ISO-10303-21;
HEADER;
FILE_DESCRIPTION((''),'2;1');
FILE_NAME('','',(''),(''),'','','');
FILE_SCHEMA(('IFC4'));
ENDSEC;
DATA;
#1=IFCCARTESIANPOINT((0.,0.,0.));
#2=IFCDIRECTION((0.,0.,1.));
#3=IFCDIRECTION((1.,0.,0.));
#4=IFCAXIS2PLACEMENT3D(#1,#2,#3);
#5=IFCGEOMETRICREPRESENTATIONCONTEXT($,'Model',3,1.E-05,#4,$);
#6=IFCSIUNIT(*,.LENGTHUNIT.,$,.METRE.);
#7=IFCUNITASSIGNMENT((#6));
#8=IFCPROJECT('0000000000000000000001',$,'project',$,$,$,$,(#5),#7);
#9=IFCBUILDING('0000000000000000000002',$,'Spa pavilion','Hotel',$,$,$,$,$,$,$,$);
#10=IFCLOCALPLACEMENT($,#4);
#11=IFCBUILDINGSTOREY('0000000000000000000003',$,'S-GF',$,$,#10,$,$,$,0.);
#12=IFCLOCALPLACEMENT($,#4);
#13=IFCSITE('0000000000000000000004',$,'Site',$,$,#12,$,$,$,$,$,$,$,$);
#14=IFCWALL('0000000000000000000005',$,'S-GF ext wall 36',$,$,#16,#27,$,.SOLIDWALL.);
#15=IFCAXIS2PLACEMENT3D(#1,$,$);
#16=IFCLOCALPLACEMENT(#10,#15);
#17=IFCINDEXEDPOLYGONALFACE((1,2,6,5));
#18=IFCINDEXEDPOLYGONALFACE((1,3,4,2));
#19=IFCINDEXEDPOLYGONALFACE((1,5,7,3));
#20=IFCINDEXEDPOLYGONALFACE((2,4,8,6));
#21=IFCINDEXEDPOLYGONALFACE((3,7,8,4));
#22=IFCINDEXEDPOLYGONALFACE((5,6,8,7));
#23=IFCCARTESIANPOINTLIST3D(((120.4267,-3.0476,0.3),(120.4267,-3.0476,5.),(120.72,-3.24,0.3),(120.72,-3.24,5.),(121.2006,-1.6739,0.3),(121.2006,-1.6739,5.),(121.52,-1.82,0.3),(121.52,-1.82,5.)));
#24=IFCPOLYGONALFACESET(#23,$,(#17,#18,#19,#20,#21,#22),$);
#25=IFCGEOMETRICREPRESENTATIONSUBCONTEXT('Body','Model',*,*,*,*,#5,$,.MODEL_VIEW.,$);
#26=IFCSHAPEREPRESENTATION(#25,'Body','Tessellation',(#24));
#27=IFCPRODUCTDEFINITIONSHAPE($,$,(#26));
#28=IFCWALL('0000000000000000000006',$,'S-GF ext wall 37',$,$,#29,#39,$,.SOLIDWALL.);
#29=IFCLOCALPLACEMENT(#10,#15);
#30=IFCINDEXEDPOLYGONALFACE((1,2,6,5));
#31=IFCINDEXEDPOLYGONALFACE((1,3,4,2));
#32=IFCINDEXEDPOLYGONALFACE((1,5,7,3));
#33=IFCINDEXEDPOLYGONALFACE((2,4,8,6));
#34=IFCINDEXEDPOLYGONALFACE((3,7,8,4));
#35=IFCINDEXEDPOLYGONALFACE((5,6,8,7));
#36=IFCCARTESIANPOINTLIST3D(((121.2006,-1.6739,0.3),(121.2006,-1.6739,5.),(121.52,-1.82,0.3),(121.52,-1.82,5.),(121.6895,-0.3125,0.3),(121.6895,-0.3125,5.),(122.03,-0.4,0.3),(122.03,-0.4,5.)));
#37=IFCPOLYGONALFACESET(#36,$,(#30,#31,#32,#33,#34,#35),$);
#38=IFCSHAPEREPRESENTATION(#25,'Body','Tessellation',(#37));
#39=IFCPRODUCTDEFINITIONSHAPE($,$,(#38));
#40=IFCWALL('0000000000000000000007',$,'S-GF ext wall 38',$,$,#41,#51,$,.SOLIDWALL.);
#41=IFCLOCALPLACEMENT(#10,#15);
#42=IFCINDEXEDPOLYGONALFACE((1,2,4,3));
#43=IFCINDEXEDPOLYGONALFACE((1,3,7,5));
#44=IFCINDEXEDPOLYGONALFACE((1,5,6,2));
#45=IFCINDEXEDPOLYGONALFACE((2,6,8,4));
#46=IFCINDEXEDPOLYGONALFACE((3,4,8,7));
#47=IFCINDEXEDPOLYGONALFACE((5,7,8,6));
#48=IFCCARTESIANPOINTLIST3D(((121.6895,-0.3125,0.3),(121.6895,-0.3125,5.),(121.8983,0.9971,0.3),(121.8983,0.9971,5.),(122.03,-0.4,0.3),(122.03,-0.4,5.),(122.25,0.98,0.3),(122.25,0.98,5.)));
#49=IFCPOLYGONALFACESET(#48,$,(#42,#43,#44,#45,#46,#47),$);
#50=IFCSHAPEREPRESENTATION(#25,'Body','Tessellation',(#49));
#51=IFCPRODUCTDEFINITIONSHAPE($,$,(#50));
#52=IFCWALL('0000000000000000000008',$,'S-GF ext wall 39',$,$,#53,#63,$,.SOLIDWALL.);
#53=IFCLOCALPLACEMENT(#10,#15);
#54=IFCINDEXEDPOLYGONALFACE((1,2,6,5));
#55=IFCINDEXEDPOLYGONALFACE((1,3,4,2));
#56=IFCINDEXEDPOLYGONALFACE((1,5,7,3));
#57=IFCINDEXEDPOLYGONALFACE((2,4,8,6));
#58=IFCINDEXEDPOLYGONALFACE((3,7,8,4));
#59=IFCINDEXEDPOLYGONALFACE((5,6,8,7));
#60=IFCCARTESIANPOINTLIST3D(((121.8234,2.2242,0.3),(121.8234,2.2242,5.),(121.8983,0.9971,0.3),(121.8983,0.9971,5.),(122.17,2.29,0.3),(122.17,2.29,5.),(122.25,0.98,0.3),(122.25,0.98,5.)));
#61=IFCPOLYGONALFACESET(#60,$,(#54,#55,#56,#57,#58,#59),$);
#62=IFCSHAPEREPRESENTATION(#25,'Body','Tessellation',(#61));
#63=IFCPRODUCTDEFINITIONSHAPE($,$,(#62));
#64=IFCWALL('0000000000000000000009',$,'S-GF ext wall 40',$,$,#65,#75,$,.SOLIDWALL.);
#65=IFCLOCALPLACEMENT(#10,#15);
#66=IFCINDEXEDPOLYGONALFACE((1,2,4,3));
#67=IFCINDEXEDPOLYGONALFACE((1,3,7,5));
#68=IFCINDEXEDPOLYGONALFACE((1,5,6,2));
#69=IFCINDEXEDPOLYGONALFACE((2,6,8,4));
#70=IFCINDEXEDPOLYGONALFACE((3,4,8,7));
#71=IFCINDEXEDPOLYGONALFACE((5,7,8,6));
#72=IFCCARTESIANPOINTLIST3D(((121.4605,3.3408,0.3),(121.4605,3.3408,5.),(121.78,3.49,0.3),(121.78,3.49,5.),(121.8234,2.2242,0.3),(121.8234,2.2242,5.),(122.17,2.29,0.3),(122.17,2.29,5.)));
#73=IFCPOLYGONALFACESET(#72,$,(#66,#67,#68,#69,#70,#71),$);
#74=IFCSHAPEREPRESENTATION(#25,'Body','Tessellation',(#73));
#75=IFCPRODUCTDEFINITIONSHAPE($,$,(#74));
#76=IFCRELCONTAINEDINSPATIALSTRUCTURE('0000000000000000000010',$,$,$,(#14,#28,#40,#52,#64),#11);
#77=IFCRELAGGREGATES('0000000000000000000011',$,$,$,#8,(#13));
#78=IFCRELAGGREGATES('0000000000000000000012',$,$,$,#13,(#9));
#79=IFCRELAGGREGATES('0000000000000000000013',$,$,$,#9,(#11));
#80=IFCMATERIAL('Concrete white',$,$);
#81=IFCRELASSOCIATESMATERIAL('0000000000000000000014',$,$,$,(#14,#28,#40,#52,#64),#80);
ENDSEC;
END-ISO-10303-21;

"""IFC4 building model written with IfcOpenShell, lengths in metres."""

from ifc_helpers import new_model, si_unit, frame, origin_with_axes, place, context, subcontext, project, spatial, polyline, outline, extrude, material, element, save


model = new_model("IFC4")

# Units and contexts
model_context = context("Model", 3, precision=1e-05, world=origin_with_axes())
body_context = subcontext(model_context, "Body", "Model", "MODEL_VIEW")
ifc_project = project(units=[si_unit("LENGTHUNIT", "METRE")], contexts=[model_context])

# Site, building, storey
site_placement = place(None, origin_with_axes())
site = spatial("IfcSite", under=ifc_project, at=site_placement, Name="Site")
building = spatial("IfcBuilding", under=site, Name="Spa pavilion", Description="Hotel")
storey_placement = place(None, origin_with_axes())
storey = spatial("IfcBuildingStorey", under=building, at=storey_placement, Name="S-GF", Elevation=0.0)

# Walls
ifc_material_1 = material(Name="Concrete white")
wall_1_placement = place(storey_placement, origin_with_axes())
element("IfcWall", 1, at=wall_1_placement, inside=storey, material=ifc_material_1, Name="S-GF ext wall 36", PredefinedType="SOLIDWALL", context=body_context, shape_type="SweptSolid", body=[
    extrude(outline(polyline([(120.72, -3.24), (121.52, -1.82), (121.2006, -1.6739), (120.4267, -3.0476), (120.72, -3.24)])), frame((0.0, 0.0, 0.3), z_axis=(0.0, 0.0, 1.0), x_axis=(1.0, 0.0, 0.0)), (0.0, 0.0, 1.0), 4.7),
])
wall_2_placement = place(storey_placement, origin_with_axes())
element("IfcWall", 2, at=wall_2_placement, inside=storey, material=ifc_material_1, Name="S-GF ext wall 37", PredefinedType="SOLIDWALL", context=body_context, shape_type="SweptSolid", body=[
    extrude(outline(polyline([(121.52, -1.82), (122.03, -0.4), (121.6895, -0.3125), (121.2006, -1.6739), (121.52, -1.82)])), frame((0.0, 0.0, 0.3), z_axis=(0.0, 0.0, 1.0), x_axis=(1.0, 0.0, 0.0)), (0.0, 0.0, 1.0), 4.7),
])
wall_3_placement = place(storey_placement, origin_with_axes())
element("IfcWall", 3, at=wall_3_placement, inside=storey, material=ifc_material_1, Name="S-GF ext wall 38", PredefinedType="SOLIDWALL", context=body_context, shape_type="SweptSolid", body=[
    extrude(outline(polyline([(122.03, -0.4), (122.25, 0.98), (121.8983, 0.9971), (121.6895, -0.3125), (122.03, -0.4)])), frame((0.0, 0.0, 0.3), z_axis=(0.0, 0.0, 1.0), x_axis=(1.0, 0.0, 0.0)), (0.0, 0.0, 1.0), 4.7),
])
wall_4_placement = place(storey_placement, origin_with_axes())
element("IfcWall", 4, at=wall_4_placement, inside=storey, material=ifc_material_1, Name="S-GF ext wall 39", PredefinedType="SOLIDWALL", context=body_context, shape_type="SweptSolid", body=[
    extrude(outline(polyline([(122.25, 0.98), (122.17, 2.29), (121.8234, 2.2242), (121.8983, 0.9971), (122.25, 0.98)])), frame((0.0, 0.0, 0.3), z_axis=(0.0, 0.0, 1.0), x_axis=(1.0, 0.0, 0.0)), (0.0, 0.0, 1.0), 4.7),
])
wall_5_placement = place(storey_placement, origin_with_axes())
element("IfcWall", 5, at=wall_5_placement, inside=storey, material=ifc_material_1, Name="S-GF ext wall 40", PredefinedType="SOLIDWALL", context=body_context, shape_type="SweptSolid", body=[
    extrude(outline(polyline([(122.17, 2.29), (121.78, 3.49), (121.4605, 3.3408), (121.8234, 2.2242), (122.17, 2.29)])), frame((0.0, 0.0, 0.3), z_axis=(0.0, 0.0, 1.0), x_axis=(1.0, 0.0, 0.0)), (0.0, 0.0, 1.0), 4.7),
])

save(model, "model.ifc")
